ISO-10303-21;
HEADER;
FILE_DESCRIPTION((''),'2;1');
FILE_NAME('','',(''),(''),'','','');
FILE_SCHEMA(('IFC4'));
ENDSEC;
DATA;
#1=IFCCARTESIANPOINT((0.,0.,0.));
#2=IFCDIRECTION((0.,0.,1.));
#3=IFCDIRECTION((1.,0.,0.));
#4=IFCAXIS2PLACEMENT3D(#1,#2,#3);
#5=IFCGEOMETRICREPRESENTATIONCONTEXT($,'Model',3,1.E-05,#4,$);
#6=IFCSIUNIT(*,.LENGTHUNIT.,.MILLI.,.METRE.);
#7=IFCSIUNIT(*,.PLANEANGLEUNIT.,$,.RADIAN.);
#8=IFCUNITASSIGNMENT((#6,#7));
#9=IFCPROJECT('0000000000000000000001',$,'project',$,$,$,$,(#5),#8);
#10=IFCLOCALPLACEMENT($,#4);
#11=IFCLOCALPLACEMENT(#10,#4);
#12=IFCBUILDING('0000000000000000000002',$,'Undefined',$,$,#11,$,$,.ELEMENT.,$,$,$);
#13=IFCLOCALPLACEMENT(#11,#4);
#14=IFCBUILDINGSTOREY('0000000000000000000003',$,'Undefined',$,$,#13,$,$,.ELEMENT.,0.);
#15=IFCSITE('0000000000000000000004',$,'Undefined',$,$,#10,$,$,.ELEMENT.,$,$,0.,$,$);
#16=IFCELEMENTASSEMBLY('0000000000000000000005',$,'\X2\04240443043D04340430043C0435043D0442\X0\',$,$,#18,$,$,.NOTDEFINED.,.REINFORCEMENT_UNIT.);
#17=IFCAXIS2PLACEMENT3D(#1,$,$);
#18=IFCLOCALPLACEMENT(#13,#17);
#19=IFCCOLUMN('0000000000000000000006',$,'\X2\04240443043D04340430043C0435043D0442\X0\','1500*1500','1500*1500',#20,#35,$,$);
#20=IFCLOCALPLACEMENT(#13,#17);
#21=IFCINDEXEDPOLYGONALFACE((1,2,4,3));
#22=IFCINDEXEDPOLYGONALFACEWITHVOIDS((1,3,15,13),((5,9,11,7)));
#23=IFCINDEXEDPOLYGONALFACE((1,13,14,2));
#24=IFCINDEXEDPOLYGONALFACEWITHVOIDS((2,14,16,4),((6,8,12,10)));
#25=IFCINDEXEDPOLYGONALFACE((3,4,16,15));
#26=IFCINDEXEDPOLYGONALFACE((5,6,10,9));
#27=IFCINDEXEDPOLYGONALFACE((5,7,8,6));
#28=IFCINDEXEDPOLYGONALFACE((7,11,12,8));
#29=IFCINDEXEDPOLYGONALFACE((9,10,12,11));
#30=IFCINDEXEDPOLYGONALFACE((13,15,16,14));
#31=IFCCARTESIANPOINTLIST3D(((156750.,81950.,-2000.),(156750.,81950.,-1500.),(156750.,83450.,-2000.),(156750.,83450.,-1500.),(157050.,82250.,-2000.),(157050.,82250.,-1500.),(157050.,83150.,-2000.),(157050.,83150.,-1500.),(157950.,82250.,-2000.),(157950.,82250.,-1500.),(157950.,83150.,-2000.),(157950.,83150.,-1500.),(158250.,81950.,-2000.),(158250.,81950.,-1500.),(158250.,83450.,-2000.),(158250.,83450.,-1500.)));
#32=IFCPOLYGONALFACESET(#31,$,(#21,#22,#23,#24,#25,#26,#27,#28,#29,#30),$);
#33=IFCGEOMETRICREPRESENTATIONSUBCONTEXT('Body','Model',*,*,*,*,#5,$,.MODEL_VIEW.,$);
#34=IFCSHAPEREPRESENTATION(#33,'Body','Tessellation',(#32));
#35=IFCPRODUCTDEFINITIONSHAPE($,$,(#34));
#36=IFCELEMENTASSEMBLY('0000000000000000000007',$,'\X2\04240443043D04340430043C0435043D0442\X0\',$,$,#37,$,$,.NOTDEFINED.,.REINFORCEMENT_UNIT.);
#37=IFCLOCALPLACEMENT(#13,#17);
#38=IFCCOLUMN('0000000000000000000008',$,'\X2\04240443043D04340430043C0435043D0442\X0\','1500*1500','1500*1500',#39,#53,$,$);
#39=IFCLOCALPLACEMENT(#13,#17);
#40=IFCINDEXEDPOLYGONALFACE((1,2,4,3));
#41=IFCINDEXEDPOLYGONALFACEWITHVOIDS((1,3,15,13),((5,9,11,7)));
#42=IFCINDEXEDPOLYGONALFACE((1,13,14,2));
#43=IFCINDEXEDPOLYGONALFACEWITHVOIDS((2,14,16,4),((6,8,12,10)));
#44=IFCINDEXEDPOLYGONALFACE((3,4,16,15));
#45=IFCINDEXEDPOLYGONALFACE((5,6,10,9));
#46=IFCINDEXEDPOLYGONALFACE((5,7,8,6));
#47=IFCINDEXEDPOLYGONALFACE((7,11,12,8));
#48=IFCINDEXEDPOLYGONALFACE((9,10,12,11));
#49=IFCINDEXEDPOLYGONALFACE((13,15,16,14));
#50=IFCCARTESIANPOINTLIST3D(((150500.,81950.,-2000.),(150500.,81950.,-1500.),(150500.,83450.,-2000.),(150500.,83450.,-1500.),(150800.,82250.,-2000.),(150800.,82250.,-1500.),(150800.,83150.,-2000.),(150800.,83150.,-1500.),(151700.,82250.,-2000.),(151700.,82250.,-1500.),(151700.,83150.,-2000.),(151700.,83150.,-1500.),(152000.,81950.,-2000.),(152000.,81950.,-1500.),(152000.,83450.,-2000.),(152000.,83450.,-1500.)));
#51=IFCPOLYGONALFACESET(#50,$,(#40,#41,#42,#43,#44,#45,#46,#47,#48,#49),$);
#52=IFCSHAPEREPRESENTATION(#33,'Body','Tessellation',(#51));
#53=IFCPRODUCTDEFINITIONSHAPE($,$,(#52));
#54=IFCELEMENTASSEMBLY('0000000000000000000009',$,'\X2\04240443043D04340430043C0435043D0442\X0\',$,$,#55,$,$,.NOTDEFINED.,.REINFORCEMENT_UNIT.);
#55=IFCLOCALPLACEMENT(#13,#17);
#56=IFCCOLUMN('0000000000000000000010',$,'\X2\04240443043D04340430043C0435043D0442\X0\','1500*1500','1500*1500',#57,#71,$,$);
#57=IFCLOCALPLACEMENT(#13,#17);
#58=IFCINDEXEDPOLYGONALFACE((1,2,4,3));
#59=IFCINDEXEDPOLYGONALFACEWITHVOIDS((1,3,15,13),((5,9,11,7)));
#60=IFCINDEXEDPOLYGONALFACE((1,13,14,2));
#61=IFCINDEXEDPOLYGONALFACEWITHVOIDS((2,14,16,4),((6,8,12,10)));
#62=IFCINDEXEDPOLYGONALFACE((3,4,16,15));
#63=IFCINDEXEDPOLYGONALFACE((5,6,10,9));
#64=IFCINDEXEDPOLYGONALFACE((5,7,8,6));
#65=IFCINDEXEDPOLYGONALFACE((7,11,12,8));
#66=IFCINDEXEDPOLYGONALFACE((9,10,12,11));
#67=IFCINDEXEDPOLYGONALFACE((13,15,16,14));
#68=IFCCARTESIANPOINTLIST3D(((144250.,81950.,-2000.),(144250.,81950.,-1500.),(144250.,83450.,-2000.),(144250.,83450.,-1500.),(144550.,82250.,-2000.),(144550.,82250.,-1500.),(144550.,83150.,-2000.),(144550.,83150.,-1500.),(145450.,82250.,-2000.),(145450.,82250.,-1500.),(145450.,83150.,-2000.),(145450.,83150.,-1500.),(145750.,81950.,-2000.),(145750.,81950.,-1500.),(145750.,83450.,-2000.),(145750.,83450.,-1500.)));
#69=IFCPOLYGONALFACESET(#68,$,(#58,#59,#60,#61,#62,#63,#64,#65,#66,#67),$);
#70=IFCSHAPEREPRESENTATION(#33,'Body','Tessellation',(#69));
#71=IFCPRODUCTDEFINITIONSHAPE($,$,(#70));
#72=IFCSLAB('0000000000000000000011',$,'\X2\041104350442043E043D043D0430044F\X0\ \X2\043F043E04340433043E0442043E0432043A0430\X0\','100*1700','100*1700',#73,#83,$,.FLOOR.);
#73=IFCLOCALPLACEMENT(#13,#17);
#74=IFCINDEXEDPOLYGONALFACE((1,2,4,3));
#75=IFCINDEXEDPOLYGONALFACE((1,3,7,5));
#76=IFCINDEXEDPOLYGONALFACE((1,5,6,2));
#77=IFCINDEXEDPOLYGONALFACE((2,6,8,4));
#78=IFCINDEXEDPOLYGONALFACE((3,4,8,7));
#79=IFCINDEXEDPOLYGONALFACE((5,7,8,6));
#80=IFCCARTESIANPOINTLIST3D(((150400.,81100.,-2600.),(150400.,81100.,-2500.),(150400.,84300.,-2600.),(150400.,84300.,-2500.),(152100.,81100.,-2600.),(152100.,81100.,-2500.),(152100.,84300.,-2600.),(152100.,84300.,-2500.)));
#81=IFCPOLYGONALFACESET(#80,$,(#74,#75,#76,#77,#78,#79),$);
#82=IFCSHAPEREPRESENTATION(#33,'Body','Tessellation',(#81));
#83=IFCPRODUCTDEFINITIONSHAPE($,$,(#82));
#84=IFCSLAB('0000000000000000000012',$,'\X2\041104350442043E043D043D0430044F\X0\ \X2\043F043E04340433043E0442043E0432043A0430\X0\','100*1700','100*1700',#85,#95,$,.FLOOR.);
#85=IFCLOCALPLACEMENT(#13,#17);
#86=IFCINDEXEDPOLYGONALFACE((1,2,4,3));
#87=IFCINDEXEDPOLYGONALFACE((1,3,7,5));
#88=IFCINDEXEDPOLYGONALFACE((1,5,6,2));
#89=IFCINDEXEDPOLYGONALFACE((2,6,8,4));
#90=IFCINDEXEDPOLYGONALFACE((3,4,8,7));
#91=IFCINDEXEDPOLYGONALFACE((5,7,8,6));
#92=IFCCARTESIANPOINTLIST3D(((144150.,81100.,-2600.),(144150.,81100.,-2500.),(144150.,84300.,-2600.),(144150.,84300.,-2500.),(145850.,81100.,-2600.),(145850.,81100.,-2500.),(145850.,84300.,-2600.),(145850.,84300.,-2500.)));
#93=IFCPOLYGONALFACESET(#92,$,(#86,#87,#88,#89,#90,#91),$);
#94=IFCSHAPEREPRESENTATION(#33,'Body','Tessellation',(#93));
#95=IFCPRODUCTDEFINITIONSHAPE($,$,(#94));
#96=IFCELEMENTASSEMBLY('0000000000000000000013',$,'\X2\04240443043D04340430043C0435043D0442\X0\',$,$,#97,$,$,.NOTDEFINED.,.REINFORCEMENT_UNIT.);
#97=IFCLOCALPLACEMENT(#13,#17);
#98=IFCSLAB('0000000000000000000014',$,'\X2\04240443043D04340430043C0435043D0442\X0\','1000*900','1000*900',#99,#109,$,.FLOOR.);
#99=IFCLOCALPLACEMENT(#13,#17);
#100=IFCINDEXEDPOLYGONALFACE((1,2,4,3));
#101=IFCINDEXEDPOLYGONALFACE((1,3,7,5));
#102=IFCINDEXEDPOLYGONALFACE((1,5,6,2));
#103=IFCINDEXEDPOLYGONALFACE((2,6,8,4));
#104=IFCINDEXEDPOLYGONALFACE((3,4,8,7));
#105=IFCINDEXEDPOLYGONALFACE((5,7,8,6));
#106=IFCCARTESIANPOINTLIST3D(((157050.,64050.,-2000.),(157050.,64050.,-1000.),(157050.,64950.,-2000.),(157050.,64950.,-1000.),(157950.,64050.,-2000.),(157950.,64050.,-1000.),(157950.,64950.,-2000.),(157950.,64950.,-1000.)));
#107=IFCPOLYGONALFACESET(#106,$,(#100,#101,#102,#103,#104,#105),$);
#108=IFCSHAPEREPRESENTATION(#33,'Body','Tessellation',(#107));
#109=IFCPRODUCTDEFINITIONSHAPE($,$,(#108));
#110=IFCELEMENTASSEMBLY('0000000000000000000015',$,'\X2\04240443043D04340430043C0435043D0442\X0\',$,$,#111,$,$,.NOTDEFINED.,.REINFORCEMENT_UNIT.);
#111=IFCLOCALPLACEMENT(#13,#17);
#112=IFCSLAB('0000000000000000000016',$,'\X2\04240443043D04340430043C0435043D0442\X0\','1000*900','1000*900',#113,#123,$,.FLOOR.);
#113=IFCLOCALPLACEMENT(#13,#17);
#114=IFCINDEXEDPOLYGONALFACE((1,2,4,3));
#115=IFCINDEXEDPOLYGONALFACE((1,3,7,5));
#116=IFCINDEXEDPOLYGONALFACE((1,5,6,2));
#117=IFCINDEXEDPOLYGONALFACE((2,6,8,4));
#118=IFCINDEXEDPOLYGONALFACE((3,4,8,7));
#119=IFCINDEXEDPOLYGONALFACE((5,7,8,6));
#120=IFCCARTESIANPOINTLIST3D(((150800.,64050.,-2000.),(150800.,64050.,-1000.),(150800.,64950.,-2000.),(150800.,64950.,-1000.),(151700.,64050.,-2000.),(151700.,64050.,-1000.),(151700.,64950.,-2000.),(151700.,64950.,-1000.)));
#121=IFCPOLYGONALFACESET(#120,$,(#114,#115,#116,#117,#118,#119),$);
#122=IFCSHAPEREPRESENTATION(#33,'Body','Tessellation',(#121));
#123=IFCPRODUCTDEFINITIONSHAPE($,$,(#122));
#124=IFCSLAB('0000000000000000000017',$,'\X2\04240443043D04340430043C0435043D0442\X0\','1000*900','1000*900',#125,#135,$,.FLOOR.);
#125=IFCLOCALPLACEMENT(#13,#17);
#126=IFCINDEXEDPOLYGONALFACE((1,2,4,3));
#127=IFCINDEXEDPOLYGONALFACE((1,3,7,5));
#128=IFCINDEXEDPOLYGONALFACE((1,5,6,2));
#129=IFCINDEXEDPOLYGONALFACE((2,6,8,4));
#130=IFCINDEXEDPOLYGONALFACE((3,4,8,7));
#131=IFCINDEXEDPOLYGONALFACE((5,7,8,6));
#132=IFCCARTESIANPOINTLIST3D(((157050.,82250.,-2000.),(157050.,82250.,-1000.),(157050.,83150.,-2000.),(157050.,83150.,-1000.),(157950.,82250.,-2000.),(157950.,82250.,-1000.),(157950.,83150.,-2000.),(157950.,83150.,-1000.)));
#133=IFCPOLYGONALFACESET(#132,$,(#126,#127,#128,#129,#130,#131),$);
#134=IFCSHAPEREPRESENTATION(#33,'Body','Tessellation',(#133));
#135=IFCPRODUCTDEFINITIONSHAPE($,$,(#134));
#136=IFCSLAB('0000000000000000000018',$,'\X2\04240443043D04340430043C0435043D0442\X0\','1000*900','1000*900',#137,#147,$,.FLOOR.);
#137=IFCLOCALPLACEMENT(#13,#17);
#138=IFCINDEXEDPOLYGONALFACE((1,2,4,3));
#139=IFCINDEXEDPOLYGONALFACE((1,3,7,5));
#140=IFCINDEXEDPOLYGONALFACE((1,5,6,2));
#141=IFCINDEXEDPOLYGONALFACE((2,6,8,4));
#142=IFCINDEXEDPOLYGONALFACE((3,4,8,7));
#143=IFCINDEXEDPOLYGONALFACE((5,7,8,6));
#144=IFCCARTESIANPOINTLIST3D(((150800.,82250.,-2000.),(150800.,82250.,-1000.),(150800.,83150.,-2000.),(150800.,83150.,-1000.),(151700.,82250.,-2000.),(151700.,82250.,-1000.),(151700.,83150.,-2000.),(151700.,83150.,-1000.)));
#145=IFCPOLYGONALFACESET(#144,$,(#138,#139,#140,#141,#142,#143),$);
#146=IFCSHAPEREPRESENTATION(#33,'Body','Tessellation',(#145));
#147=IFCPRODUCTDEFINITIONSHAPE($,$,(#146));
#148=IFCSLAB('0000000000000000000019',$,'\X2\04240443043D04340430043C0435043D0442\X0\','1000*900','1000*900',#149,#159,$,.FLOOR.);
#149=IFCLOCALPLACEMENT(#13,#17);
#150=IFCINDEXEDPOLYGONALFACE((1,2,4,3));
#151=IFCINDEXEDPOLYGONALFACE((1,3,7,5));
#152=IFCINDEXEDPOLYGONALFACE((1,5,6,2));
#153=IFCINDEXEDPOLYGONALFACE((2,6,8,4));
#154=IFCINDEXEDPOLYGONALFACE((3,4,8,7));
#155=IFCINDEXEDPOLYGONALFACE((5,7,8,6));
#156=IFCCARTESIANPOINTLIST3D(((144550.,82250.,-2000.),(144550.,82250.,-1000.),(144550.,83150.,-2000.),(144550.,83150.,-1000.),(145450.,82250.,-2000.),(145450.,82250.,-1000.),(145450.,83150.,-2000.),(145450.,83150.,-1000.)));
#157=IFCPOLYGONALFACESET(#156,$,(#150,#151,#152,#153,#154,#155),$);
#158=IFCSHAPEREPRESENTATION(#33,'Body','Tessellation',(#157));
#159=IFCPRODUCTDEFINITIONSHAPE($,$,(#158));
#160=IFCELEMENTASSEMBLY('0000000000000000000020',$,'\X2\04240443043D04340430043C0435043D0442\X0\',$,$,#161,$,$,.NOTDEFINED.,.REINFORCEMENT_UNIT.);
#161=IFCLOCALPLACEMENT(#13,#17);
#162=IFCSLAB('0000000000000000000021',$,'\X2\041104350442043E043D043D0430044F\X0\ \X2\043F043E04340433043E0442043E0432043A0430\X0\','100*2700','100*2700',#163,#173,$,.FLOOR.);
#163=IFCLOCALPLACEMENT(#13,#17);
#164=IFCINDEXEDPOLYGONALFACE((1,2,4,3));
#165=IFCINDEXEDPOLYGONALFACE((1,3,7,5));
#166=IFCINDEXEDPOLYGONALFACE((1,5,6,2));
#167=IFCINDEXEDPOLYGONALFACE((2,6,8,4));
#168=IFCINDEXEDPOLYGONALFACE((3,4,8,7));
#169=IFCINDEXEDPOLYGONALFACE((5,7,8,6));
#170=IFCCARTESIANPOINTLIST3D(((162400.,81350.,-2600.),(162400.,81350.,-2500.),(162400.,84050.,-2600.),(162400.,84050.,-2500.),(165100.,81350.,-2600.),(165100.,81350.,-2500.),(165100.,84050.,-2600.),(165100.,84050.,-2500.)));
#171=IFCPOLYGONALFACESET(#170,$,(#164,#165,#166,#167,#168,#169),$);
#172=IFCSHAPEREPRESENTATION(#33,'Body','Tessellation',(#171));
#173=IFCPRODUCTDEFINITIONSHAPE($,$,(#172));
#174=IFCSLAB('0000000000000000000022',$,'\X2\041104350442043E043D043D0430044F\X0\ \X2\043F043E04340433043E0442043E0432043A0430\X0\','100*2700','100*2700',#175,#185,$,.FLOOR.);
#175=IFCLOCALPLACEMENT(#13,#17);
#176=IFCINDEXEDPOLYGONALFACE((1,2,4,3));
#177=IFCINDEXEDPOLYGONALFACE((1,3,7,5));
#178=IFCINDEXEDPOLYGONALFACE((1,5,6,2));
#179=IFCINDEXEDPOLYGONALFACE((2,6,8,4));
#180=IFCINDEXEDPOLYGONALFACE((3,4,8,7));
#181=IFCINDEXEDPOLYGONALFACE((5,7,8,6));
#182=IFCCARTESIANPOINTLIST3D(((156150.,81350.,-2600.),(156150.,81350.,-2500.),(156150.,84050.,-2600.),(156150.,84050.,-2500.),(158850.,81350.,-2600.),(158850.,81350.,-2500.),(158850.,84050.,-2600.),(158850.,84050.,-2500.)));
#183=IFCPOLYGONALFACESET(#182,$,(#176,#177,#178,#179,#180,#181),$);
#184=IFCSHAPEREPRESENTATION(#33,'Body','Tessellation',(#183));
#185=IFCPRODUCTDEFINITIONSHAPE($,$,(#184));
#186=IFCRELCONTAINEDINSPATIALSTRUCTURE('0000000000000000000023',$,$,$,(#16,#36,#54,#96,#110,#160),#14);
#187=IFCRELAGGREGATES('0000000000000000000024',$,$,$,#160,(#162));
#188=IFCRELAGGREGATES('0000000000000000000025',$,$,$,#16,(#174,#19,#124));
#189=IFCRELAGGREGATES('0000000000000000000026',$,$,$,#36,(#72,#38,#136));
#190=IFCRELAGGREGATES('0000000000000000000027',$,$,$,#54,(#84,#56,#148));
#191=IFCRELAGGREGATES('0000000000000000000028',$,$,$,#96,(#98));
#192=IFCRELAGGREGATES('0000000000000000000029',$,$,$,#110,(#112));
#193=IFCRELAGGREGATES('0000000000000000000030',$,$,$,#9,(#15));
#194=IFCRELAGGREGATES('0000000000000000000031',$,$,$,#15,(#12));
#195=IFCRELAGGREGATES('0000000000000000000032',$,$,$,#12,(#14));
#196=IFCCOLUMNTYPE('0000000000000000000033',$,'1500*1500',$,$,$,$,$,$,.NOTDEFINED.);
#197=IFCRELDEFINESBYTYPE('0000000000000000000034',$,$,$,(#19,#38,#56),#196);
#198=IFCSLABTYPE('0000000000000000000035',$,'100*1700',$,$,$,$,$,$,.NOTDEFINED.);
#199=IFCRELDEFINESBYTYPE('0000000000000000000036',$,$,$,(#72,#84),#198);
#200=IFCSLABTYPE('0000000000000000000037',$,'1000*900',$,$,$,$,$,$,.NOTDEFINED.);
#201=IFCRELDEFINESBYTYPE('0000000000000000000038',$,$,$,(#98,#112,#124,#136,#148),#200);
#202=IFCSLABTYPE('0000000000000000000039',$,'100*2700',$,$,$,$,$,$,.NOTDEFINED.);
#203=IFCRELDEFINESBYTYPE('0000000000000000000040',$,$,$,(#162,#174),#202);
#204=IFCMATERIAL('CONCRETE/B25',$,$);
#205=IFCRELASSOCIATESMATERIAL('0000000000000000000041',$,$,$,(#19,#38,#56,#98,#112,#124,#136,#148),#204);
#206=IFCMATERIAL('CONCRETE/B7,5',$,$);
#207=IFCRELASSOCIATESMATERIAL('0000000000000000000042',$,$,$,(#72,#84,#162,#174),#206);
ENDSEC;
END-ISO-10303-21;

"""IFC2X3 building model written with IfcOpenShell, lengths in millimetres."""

from ifc_helpers import new_model, si_unit, frame, origin_with_axes, origin_2d_with_axis, place, context, subcontext, project, spatial, polyline, rectangle, outline, extrude, boolean, material, type_object, element, aggregate, save


model = new_model("IFC2X3")

# Units and contexts
model_context = context("Model", 3, precision=1e-05, world=origin_with_axes())
body_context = subcontext(model_context, "Body", "Model", "MODEL_VIEW")
ifc_project = project(units=[si_unit("LENGTHUNIT", "METRE", prefix="MILLI"), si_unit("PLANEANGLEUNIT", "RADIAN")], contexts=[model_context])

# Site, building, storey
site_placement = place(None, origin_with_axes())
site = spatial("IfcSite", under=ifc_project, at=site_placement, Name="Undefined", CompositionType="ELEMENT", RefElevation=0.0)
building_placement = place(site_placement, origin_with_axes())
building = spatial("IfcBuilding", under=site, at=building_placement, Name="Undefined", CompositionType="ELEMENT")
storey_placement = place(building_placement, origin_with_axes())
storey = spatial("IfcBuildingStorey", under=building, at=storey_placement, Name="Undefined", CompositionType="ELEMENT", Elevation=0.0)

# Element assemblies, columns
assembly_1_placement = place(storey_placement, origin_with_axes())
assembly_1 = element("IfcElementAssembly", 1, at=assembly_1_placement, inside=storey, Name="Фундамент", AssemblyPlace="NOTDEFINED", PredefinedType="REINFORCEMENT_UNIT")
ifc_material_1 = material(Name="CONCRETE/B25")
column_type = type_object("IfcColumnType", Name="1500*1500", PredefinedType="NOTDEFINED")
column_1_placement = place(assembly_1_placement, frame((157500.0, 82700.0, -2000.0), z_axis=(0.0, 0.0, 1.0), x_axis=(0.0, -1.0, 0.0)))
column_1 = element("IfcColumn", 2, at=column_1_placement, type_object=column_type, material=ifc_material_1, Name="Фундамент", Description="1500*1500", ObjectType="1500*1500", context=body_context, shape_type="CSG", body=[
    boolean("DIFFERENCE", extrude(rectangle(XDim=1500.0, YDim=1500.0, at=origin_2d_with_axis()), frame((0.0, 0.0, 500.0), z_axis=(0.0, 0.0, -1.0), x_axis=(0.0, 1.0, 0.0)), (0.0, 0.0, 1.0), 500.0), extrude(outline(polyline([(0.0, 0.0), (900.0, 0.0), (900.0, 900.0), (0.0, 900.0), (0.0, 0.0)])), frame((-450.0, -450.0, -100.0), z_axis=(0.0, 0.0, 1.0), x_axis=(1.0, 0.0, 0.0)), (0.0, 0.0, 1.0), 700.0)),
])
assembly_2_placement = place(storey_placement, origin_with_axes())
assembly_2 = element("IfcElementAssembly", 3, at=assembly_2_placement, inside=storey, Name="Фундамент", AssemblyPlace="NOTDEFINED", PredefinedType="REINFORCEMENT_UNIT")
column_2_placement = place(assembly_2_placement, frame((151250.0, 82700.0, -2000.0), z_axis=(0.0, 0.0, 1.0), x_axis=(0.0, -1.0, 0.0)))
column_2 = element("IfcColumn", 4, at=column_2_placement, type_object=column_type, material=ifc_material_1, Name="Фундамент", Description="1500*1500", ObjectType="1500*1500", context=body_context, shape_type="CSG", body=[
    boolean("DIFFERENCE", extrude(rectangle(XDim=1500.0, YDim=1500.0, at=origin_2d_with_axis()), frame((0.0, 0.0, 500.0), z_axis=(0.0, 0.0, -1.0), x_axis=(0.0, 1.0, 0.0)), (0.0, 0.0, 1.0), 500.0), extrude(outline(polyline([(0.0, 0.0), (900.0, 0.0), (900.0, 900.0), (0.0, 900.0), (0.0, 0.0)])), frame((-450.0, -450.0, -100.0), z_axis=(0.0, 0.0, 1.0), x_axis=(1.0, 0.0, 0.0)), (0.0, 0.0, 1.0), 700.0)),
])
assembly_3_placement = place(storey_placement, origin_with_axes())
assembly_3 = element("IfcElementAssembly", 5, at=assembly_3_placement, inside=storey, Name="Фундамент", AssemblyPlace="NOTDEFINED", PredefinedType="REINFORCEMENT_UNIT")
column_3_placement = place(assembly_3_placement, frame((145000.0, 82700.0, -2000.0), z_axis=(0.0, 0.0, 1.0), x_axis=(0.0, -1.0, 0.0)))
column_3 = element("IfcColumn", 6, at=column_3_placement, type_object=column_type, material=ifc_material_1, Name="Фундамент", Description="1500*1500", ObjectType="1500*1500", context=body_context, shape_type="CSG", body=[
    boolean("DIFFERENCE", extrude(rectangle(XDim=1500.0, YDim=1500.0, at=origin_2d_with_axis()), frame((0.0, 0.0, 500.0), z_axis=(0.0, 0.0, -1.0), x_axis=(0.0, 1.0, 0.0)), (0.0, 0.0, 1.0), 500.0), extrude(outline(polyline([(0.0, 0.0), (900.0, 0.0), (900.0, 900.0), (0.0, 900.0), (0.0, 0.0)])), frame((-450.0, -450.0, -100.0), z_axis=(0.0, 0.0, 1.0), x_axis=(1.0, 0.0, 0.0)), (0.0, 0.0, 1.0), 700.0)),
])

# Slabs
ifc_material_2 = material(Name="CONCRETE/B7,5")
slab_type_1 = type_object("IfcSlabType", Name="100*1700", PredefinedType="NOTDEFINED")
slab_1_placement = place(assembly_2_placement, frame((150400.0, 84300.0, -2550.0), z_axis=(0.0, 0.0, 1.0), x_axis=(0.0, -1.0, 0.0)))
slab_1 = element("IfcSlab", 7, at=slab_1_placement, type_object=slab_type_1, material=ifc_material_2, Name="Бетонная подготовка", Description="100*1700", ObjectType="100*1700", PredefinedType="FLOOR", context=body_context, shape_type="SweptSolid", body=[
    extrude(outline(polyline([(0.0, 0.0), (3200.0, 0.0), (3200.0, 1700.0), (0.0, 1700.0), (0.0, 0.0)])), frame((0.0, 0.0, -50.0), z_axis=(0.0, 0.0, 1.0), x_axis=(1.0, 0.0, 0.0)), (0.0, 0.0, 1.0), 100.0),
])
slab_2_placement = place(assembly_3_placement, frame((144150.0, 84300.0, -2550.0), z_axis=(0.0, 0.0, 1.0), x_axis=(0.0, -1.0, 0.0)))
slab_2 = element("IfcSlab", 8, at=slab_2_placement, type_object=slab_type_1, material=ifc_material_2, Name="Бетонная подготовка", Description="100*1700", ObjectType="100*1700", PredefinedType="FLOOR", context=body_context, shape_type="SweptSolid", body=[
    extrude(outline(polyline([(0.0, 0.0), (3200.0, 0.0), (3200.0, 1700.0), (0.0, 1700.0), (0.0, 0.0)])), frame((0.0, 0.0, -50.0), z_axis=(0.0, 0.0, 1.0), x_axis=(1.0, 0.0, 0.0)), (0.0, 0.0, 1.0), 100.0),
])

# Element assemblies, slabs
assembly_4_placement = place(storey_placement, origin_with_axes())
assembly_4 = element("IfcElementAssembly", 9, at=assembly_4_placement, inside=storey, Name="Фундамент", AssemblyPlace="NOTDEFINED", PredefinedType="REINFORCEMENT_UNIT")
slab_type_2 = type_object("IfcSlabType", Name="1000*900", PredefinedType="NOTDEFINED")
slab_3_placement = place(assembly_4_placement, frame((157050.0, 64950.0, -1500.0), z_axis=(0.0, 0.0, 1.0), x_axis=(0.0, -1.0, 0.0)))
slab_3 = element("IfcSlab", 10, at=slab_3_placement, type_object=slab_type_2, material=ifc_material_1, Name="Фундамент", Description="1000*900", ObjectType="1000*900", PredefinedType="FLOOR", context=body_context, shape_type="SweptSolid", body=[
    extrude(outline(polyline([(0.0, 0.0), (900.0, 0.0), (900.0, 900.0), (0.0, 900.0), (0.0, 0.0)])), frame((0.0, 0.0, -500.0), z_axis=(0.0, 0.0, 1.0), x_axis=(1.0, 0.0, 0.0)), (0.0, 0.0, 1.0), 1000.0),
])
assembly_5_placement = place(storey_placement, origin_with_axes())
assembly_5 = element("IfcElementAssembly", 11, at=assembly_5_placement, inside=storey, Name="Фундамент", AssemblyPlace="NOTDEFINED", PredefinedType="REINFORCEMENT_UNIT")
slab_4_placement = place(assembly_5_placement, frame((150800.0, 64950.0, -1500.0), z_axis=(0.0, 0.0, 1.0), x_axis=(0.0, -1.0, 0.0)))
slab_4 = element("IfcSlab", 12, at=slab_4_placement, type_object=slab_type_2, material=ifc_material_1, Name="Фундамент", Description="1000*900", ObjectType="1000*900", PredefinedType="FLOOR", context=body_context, shape_type="SweptSolid", body=[
    extrude(outline(polyline([(0.0, 0.0), (900.0, 0.0), (900.0, 900.0), (0.0, 900.0), (0.0, 0.0)])), frame((0.0, 0.0, -500.0), z_axis=(0.0, 0.0, 1.0), x_axis=(1.0, 0.0, 0.0)), (0.0, 0.0, 1.0), 1000.0),
])

# Slabs
slab_5_placement = place(assembly_1_placement, frame((157050.0, 83150.0, -1500.0), z_axis=(0.0, 0.0, 1.0), x_axis=(0.0, -1.0, 0.0)))
slab_5 = element("IfcSlab", 13, at=slab_5_placement, type_object=slab_type_2, material=ifc_material_1, Name="Фундамент", Description="1000*900", ObjectType="1000*900", PredefinedType="FLOOR", context=body_context, shape_type="SweptSolid", body=[
    extrude(outline(polyline([(0.0, 0.0), (900.0, 0.0), (900.0, 900.0), (0.0, 900.0), (0.0, 0.0)])), frame((0.0, 0.0, -500.0), z_axis=(0.0, 0.0, 1.0), x_axis=(1.0, 0.0, 0.0)), (0.0, 0.0, 1.0), 1000.0),
])
slab_6_placement = place(assembly_2_placement, frame((150800.0, 83150.0, -1500.0), z_axis=(0.0, 0.0, 1.0), x_axis=(0.0, -1.0, 0.0)))
slab_6 = element("IfcSlab", 14, at=slab_6_placement, type_object=slab_type_2, material=ifc_material_1, Name="Фундамент", Description="1000*900", ObjectType="1000*900", PredefinedType="FLOOR", context=body_context, shape_type="SweptSolid", body=[
    extrude(outline(polyline([(0.0, 0.0), (900.0, 0.0), (900.0, 900.0), (0.0, 900.0), (0.0, 0.0)])), frame((0.0, 0.0, -500.0), z_axis=(0.0, 0.0, 1.0), x_axis=(1.0, 0.0, 0.0)), (0.0, 0.0, 1.0), 1000.0),
])
slab_7_placement = place(assembly_3_placement, frame((144550.0, 83150.0, -1500.0), z_axis=(0.0, 0.0, 1.0), x_axis=(0.0, -1.0, 0.0)))
slab_7 = element("IfcSlab", 15, at=slab_7_placement, type_object=slab_type_2, material=ifc_material_1, Name="Фундамент", Description="1000*900", ObjectType="1000*900", PredefinedType="FLOOR", context=body_context, shape_type="SweptSolid", body=[
    extrude(outline(polyline([(0.0, 0.0), (900.0, 0.0), (900.0, 900.0), (0.0, 900.0), (0.0, 0.0)])), frame((0.0, 0.0, -500.0), z_axis=(0.0, 0.0, 1.0), x_axis=(1.0, 0.0, 0.0)), (0.0, 0.0, 1.0), 1000.0),
])

# Element assembly, slab
assembly_6_placement = place(storey_placement, origin_with_axes())
assembly_6 = element("IfcElementAssembly", 16, at=assembly_6_placement, inside=storey, Name="Фундамент", AssemblyPlace="NOTDEFINED", PredefinedType="REINFORCEMENT_UNIT")
slab_type_3 = type_object("IfcSlabType", Name="100*2700", PredefinedType="NOTDEFINED")
slab_8_placement = place(assembly_6_placement, frame((162400.0, 84050.0, -2550.0), z_axis=(0.0, 0.0, 1.0), x_axis=(0.0, -1.0, 0.0)))
slab_8 = element("IfcSlab", 17, at=slab_8_placement, type_object=slab_type_3, material=ifc_material_2, Name="Бетонная подготовка", Description="100*2700", ObjectType="100*2700", PredefinedType="FLOOR", context=body_context, shape_type="SweptSolid", body=[
    extrude(outline(polyline([(0.0, 0.0), (2700.0, 0.0), (2700.0, 2700.0), (0.0, 2700.0), (0.0, 0.0)])), frame((0.0, 0.0, -50.0), z_axis=(0.0, 0.0, 1.0), x_axis=(1.0, 0.0, 0.0)), (0.0, 0.0, 1.0), 100.0),
])
aggregate(assembly_6, [slab_8])

# Slab
slab_9_placement = place(assembly_1_placement, frame((156150.0, 84050.0, -2550.0), z_axis=(0.0, 0.0, 1.0), x_axis=(0.0, -1.0, 0.0)))
slab_9 = element("IfcSlab", 18, at=slab_9_placement, type_object=slab_type_3, material=ifc_material_2, Name="Бетонная подготовка", Description="100*2700", ObjectType="100*2700", PredefinedType="FLOOR", context=body_context, shape_type="SweptSolid", body=[
    extrude(outline(polyline([(0.0, 0.0), (2700.0, 0.0), (2700.0, 2700.0), (0.0, 2700.0), (0.0, 0.0)])), frame((0.0, 0.0, -50.0), z_axis=(0.0, 0.0, 1.0), x_axis=(1.0, 0.0, 0.0)), (0.0, 0.0, 1.0), 100.0),
])
aggregate(assembly_1, [slab_9, column_1, slab_5])
aggregate(assembly_2, [slab_1, column_2, slab_6])
aggregate(assembly_3, [slab_2, column_3, slab_7])
aggregate(assembly_4, [slab_3])
aggregate(assembly_5, [slab_4])

save(model, "model.ifc")
